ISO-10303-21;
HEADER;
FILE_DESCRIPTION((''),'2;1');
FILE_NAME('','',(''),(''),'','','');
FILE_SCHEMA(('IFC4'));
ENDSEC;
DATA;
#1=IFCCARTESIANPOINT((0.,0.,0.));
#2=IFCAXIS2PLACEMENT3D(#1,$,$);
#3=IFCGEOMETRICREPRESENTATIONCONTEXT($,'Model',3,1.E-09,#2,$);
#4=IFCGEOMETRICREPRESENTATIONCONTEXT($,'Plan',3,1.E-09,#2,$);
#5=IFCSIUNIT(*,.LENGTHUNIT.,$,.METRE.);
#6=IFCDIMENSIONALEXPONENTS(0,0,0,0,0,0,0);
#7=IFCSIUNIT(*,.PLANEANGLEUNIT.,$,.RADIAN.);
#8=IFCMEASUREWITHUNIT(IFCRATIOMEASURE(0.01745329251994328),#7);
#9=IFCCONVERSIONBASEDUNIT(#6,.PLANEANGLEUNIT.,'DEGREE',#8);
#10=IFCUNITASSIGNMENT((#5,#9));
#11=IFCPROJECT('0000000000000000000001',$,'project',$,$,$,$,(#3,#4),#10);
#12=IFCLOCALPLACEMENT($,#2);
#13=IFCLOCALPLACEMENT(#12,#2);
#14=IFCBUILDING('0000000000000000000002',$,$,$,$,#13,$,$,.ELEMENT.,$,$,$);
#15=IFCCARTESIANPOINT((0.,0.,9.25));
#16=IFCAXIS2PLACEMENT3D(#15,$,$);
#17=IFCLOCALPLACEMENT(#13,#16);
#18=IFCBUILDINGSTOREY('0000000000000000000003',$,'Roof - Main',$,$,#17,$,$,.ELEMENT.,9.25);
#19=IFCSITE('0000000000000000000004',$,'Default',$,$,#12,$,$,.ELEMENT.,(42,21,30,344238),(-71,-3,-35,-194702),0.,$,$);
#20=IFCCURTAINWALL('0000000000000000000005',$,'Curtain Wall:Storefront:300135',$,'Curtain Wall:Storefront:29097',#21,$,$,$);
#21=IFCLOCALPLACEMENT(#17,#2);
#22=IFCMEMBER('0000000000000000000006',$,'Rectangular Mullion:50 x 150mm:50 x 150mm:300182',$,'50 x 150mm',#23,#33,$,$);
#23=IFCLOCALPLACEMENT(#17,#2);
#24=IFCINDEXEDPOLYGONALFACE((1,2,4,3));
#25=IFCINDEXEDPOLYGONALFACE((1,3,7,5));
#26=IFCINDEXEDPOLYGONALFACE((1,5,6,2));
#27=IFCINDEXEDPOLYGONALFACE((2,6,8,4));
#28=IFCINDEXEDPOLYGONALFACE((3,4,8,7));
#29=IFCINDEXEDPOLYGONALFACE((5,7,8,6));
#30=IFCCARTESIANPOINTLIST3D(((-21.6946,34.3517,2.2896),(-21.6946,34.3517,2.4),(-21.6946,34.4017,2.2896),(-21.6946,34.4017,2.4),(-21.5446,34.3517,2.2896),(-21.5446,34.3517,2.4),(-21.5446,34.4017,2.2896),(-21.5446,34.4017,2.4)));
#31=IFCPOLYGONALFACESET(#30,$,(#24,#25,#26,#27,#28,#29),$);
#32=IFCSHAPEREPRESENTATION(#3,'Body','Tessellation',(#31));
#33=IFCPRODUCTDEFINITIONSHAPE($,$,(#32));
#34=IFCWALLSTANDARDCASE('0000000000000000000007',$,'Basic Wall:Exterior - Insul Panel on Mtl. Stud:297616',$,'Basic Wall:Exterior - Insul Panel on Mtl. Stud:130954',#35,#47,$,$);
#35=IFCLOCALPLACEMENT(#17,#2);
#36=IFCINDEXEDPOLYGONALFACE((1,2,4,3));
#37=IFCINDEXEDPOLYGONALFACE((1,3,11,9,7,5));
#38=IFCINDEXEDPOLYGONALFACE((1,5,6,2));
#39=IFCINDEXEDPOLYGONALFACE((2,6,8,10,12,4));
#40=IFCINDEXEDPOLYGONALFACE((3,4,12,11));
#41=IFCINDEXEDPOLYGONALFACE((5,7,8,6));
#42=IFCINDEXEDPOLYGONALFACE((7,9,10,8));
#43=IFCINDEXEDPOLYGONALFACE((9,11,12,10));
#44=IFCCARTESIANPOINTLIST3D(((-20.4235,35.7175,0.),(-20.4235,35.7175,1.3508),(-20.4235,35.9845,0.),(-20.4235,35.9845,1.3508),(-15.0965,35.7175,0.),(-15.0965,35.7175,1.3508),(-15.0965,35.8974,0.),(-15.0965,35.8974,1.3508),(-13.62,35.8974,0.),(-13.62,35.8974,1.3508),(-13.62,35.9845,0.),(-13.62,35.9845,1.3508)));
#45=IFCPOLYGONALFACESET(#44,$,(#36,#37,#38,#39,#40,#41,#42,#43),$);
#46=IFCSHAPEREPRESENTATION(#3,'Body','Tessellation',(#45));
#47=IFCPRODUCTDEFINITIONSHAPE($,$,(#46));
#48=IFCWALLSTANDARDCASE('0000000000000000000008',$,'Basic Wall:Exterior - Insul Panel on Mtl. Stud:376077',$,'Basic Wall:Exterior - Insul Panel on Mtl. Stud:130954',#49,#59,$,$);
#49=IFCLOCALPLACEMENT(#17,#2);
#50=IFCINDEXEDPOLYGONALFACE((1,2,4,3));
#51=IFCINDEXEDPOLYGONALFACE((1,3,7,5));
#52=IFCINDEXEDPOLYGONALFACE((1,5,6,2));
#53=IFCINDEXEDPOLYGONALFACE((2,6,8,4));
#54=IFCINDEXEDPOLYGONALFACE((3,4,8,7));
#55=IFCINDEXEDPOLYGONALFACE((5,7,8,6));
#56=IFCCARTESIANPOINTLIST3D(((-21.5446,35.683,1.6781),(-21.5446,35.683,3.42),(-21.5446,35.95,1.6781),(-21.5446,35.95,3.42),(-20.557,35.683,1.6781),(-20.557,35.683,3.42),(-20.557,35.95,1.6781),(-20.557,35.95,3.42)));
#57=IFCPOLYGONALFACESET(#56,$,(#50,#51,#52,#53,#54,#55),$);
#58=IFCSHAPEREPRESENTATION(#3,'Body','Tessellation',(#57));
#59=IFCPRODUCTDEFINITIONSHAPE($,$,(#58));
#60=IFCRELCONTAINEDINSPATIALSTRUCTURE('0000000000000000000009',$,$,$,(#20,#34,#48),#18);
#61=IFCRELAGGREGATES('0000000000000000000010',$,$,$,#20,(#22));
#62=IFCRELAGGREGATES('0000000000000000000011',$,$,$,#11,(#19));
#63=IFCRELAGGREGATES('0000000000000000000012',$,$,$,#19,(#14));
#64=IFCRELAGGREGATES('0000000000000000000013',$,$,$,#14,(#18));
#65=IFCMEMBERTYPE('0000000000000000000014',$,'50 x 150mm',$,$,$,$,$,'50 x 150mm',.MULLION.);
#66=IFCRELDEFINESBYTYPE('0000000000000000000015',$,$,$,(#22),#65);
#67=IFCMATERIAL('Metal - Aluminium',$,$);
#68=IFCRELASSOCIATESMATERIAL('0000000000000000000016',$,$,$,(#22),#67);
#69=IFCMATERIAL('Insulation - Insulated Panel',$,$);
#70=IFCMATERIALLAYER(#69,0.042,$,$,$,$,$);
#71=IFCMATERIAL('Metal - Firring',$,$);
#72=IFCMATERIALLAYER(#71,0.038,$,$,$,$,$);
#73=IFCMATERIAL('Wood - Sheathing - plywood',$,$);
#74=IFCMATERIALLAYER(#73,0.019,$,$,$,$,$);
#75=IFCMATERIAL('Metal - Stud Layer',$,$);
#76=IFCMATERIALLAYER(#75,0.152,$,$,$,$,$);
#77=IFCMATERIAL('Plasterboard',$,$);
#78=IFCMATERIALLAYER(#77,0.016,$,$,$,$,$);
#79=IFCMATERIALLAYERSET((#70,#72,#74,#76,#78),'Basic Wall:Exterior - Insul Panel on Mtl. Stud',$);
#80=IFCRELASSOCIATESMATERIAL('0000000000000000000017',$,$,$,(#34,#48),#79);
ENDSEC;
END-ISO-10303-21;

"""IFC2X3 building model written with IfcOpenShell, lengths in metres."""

from ifc_helpers import new_model, entity, si_unit, converted_unit, frame, frame_2d, origin, origin_2d_with_axis, place, context, project, spatial, polyline, rectangle, extrude, clip, bounded_halfspace, source, transform, mapped, material, layer, layer_set, layer_usage, type_object, type_shapes, element, aggregate, save


model = new_model("IFC2X3")

# Units and contexts
model_context = context("Model", 3, precision=1e-09, world=origin())
plan_context = context("Plan", 3, precision=1e-09, world=origin())
ifc_project = project(units=[si_unit("LENGTHUNIT", "METRE"), converted_unit("PLANEANGLEUNIT", "DEGREE", entity("IfcRatioMeasure", 0.01745329251994328), si_unit("PLANEANGLEUNIT", "RADIAN"), dimensions=[0, 0, 0, 0, 0, 0, 0])], contexts=[model_context, plan_context])

# Site, building, storey
site_placement = place(None, origin())
site = spatial("IfcSite", under=ifc_project, at=site_placement, Name="Default", CompositionType="ELEMENT", RefLatitude=(42, 21, 30, 344238), RefLongitude=(-71, -3, -35, -194702), RefElevation=0.0)
building_placement = place(site_placement, origin())
building = spatial("IfcBuilding", under=site, at=building_placement, CompositionType="ELEMENT")
storey_placement = place(building_placement, frame((0.0, 0.0, 9.25)))
storey = spatial("IfcBuildingStorey", under=building, at=storey_placement, Name="Roof - Main", CompositionType="ELEMENT", Elevation=9.25)

# Curtain wall, member
ifc_material_1 = material(Name="Metal - Aluminium")
curtain_wall_1_placement = place(storey_placement, origin())
curtain_wall_1 = element("IfcCurtainWall", 1, at=curtain_wall_1_placement, inside=storey, Name="Curtain Wall:Storefront:300135", ObjectType="Curtain Wall:Storefront:29097")
member_type_1 = type_object("IfcMemberType", Name="50 x 150mm", ElementType="50 x 150mm", PredefinedType="MULLION")
shared_shape_1 = source(origin(), model_context, "Body", "SweptSolid", [
    extrude(rectangle(XDim=0.05, YDim=0.15, at=origin_2d_with_axis()), frame((0.0, 0.0, -0.1104), z_axis=(0.0, 0.0, 1.0), x_axis=(-1.0, 0.0, 0.0)), (0.0, 0.0, 1.0), 0.1104),
])
type_shapes(member_type_1, [shared_shape_1])
member_1_placement = place(storey_placement, frame((-21.6196, 34.3767, 2.2896), z_axis=(0.0, 0.0, -1.0), x_axis=(0.0, -1.0, 0.0)))
member_1 = element("IfcMember", 2, at=member_1_placement, type_object=member_type_1, material=ifc_material_1, Name="Rectangular Mullion:50 x 150mm:50 x 150mm:300182", ObjectType="50 x 150mm", context=model_context, shape_type="MappedRepresentation", body=[
    mapped(shared_shape_1, transform((0.0, 0.0, 0.0), scale=1.0)),
])

aggregate(curtain_wall_1, [member_1])

# Walls
ifc_material_2 = material(Name="Insulation - Insulated Panel")
ifc_layer_1 = layer(ifc_material_2, 0.042)
ifc_material_3 = material(Name="Metal - Firring")
ifc_layer_2 = layer(ifc_material_3, 0.038)
ifc_material_4 = material(Name="Wood - Sheathing - plywood")
ifc_layer_3 = layer(ifc_material_4, 0.019)
ifc_material_5 = material(Name="Metal - Stud Layer")
ifc_layer_4 = layer(ifc_material_5, 0.152)
ifc_material_6 = material(Name="Plasterboard")
ifc_layer_5 = layer(ifc_material_6, 0.016)
ifc_layer_set = layer_set([ifc_layer_1, ifc_layer_2, ifc_layer_3, ifc_layer_4, ifc_layer_5], Name="Basic Wall:Exterior - Insul Panel on Mtl. Stud")
ifc_layer_usage_1 = layer_usage(ifc_layer_set, "AXIS2", "NEGATIVE", 0.1335)
wall_1_placement = place(storey_placement, frame((-20.4235, 35.851, 0.0)))
element("IfcWallStandardCase", 3, at=wall_1_placement, inside=storey, material=ifc_layer_usage_1, Name="Basic Wall:Exterior - Insul Panel on Mtl. Stud:297616", ObjectType="Basic Wall:Exterior - Insul Panel on Mtl. Stud:130954", context=model_context, shape_type="Clipping", body=[
    clip(clip(extrude(rectangle(XDim=6.8035, YDim=0.267, at=frame_2d((3.4018, 0.0), x_axis=(-1.0, 0.0))), origin(), (0.0, 0.0, 1.0), 1.3508), bounded_halfspace(frame((5.327, 0.0464, 1.3508), z_axis=(0.0, 1.0, 0.0), x_axis=(-1.0, 0.0, 0.0)), True, frame((5.327, 0.0464, 1.3508), z_axis=(0.0, 1.0, 0.0), x_axis=(-1.0, 0.0, 0.0)), polyline([(0.0, 0.0), (-1.4765, 0.0), (-1.4765, -0.8938), (-1.4765, -1.3508), (0.0, -1.3508), (0.0, 0.0)]))), bounded_halfspace(frame((5.327, 0.0464, 0.0), z_axis=(-1.0, 0.0, 0.0), x_axis=(0.0, -1.0, 0.0)), True, frame((5.327, 0.0464, 0.0), z_axis=(-1.0, 0.0, 0.0), x_axis=(0.0, -1.0, 0.0)), polyline([(0.0, 0.0), (0.1799, 0.0), (0.1799, 1.35), (0.1799, 1.3508), (0.0, 1.3508), (0.0, 0.0)]))),
])
ifc_layer_usage_2 = layer_usage(ifc_layer_set, "AXIS2", "POSITIVE", -0.1335)
wall_2_placement = place(storey_placement, frame((-21.5446, 35.8165, 1.6781)))
element("IfcWallStandardCase", 4, at=wall_2_placement, inside=storey, material=ifc_layer_usage_2, Name="Basic Wall:Exterior - Insul Panel on Mtl. Stud:376077", ObjectType="Basic Wall:Exterior - Insul Panel on Mtl. Stud:130954", context=model_context, shape_type="SweptSolid", body=[
    extrude(rectangle(XDim=0.9876, YDim=0.267, at=frame_2d((0.4938, 0.0), x_axis=(-1.0, 0.0))), origin(), (0.0, 0.0, 1.0), 1.7419),
])

save(model, "model.ifc")
